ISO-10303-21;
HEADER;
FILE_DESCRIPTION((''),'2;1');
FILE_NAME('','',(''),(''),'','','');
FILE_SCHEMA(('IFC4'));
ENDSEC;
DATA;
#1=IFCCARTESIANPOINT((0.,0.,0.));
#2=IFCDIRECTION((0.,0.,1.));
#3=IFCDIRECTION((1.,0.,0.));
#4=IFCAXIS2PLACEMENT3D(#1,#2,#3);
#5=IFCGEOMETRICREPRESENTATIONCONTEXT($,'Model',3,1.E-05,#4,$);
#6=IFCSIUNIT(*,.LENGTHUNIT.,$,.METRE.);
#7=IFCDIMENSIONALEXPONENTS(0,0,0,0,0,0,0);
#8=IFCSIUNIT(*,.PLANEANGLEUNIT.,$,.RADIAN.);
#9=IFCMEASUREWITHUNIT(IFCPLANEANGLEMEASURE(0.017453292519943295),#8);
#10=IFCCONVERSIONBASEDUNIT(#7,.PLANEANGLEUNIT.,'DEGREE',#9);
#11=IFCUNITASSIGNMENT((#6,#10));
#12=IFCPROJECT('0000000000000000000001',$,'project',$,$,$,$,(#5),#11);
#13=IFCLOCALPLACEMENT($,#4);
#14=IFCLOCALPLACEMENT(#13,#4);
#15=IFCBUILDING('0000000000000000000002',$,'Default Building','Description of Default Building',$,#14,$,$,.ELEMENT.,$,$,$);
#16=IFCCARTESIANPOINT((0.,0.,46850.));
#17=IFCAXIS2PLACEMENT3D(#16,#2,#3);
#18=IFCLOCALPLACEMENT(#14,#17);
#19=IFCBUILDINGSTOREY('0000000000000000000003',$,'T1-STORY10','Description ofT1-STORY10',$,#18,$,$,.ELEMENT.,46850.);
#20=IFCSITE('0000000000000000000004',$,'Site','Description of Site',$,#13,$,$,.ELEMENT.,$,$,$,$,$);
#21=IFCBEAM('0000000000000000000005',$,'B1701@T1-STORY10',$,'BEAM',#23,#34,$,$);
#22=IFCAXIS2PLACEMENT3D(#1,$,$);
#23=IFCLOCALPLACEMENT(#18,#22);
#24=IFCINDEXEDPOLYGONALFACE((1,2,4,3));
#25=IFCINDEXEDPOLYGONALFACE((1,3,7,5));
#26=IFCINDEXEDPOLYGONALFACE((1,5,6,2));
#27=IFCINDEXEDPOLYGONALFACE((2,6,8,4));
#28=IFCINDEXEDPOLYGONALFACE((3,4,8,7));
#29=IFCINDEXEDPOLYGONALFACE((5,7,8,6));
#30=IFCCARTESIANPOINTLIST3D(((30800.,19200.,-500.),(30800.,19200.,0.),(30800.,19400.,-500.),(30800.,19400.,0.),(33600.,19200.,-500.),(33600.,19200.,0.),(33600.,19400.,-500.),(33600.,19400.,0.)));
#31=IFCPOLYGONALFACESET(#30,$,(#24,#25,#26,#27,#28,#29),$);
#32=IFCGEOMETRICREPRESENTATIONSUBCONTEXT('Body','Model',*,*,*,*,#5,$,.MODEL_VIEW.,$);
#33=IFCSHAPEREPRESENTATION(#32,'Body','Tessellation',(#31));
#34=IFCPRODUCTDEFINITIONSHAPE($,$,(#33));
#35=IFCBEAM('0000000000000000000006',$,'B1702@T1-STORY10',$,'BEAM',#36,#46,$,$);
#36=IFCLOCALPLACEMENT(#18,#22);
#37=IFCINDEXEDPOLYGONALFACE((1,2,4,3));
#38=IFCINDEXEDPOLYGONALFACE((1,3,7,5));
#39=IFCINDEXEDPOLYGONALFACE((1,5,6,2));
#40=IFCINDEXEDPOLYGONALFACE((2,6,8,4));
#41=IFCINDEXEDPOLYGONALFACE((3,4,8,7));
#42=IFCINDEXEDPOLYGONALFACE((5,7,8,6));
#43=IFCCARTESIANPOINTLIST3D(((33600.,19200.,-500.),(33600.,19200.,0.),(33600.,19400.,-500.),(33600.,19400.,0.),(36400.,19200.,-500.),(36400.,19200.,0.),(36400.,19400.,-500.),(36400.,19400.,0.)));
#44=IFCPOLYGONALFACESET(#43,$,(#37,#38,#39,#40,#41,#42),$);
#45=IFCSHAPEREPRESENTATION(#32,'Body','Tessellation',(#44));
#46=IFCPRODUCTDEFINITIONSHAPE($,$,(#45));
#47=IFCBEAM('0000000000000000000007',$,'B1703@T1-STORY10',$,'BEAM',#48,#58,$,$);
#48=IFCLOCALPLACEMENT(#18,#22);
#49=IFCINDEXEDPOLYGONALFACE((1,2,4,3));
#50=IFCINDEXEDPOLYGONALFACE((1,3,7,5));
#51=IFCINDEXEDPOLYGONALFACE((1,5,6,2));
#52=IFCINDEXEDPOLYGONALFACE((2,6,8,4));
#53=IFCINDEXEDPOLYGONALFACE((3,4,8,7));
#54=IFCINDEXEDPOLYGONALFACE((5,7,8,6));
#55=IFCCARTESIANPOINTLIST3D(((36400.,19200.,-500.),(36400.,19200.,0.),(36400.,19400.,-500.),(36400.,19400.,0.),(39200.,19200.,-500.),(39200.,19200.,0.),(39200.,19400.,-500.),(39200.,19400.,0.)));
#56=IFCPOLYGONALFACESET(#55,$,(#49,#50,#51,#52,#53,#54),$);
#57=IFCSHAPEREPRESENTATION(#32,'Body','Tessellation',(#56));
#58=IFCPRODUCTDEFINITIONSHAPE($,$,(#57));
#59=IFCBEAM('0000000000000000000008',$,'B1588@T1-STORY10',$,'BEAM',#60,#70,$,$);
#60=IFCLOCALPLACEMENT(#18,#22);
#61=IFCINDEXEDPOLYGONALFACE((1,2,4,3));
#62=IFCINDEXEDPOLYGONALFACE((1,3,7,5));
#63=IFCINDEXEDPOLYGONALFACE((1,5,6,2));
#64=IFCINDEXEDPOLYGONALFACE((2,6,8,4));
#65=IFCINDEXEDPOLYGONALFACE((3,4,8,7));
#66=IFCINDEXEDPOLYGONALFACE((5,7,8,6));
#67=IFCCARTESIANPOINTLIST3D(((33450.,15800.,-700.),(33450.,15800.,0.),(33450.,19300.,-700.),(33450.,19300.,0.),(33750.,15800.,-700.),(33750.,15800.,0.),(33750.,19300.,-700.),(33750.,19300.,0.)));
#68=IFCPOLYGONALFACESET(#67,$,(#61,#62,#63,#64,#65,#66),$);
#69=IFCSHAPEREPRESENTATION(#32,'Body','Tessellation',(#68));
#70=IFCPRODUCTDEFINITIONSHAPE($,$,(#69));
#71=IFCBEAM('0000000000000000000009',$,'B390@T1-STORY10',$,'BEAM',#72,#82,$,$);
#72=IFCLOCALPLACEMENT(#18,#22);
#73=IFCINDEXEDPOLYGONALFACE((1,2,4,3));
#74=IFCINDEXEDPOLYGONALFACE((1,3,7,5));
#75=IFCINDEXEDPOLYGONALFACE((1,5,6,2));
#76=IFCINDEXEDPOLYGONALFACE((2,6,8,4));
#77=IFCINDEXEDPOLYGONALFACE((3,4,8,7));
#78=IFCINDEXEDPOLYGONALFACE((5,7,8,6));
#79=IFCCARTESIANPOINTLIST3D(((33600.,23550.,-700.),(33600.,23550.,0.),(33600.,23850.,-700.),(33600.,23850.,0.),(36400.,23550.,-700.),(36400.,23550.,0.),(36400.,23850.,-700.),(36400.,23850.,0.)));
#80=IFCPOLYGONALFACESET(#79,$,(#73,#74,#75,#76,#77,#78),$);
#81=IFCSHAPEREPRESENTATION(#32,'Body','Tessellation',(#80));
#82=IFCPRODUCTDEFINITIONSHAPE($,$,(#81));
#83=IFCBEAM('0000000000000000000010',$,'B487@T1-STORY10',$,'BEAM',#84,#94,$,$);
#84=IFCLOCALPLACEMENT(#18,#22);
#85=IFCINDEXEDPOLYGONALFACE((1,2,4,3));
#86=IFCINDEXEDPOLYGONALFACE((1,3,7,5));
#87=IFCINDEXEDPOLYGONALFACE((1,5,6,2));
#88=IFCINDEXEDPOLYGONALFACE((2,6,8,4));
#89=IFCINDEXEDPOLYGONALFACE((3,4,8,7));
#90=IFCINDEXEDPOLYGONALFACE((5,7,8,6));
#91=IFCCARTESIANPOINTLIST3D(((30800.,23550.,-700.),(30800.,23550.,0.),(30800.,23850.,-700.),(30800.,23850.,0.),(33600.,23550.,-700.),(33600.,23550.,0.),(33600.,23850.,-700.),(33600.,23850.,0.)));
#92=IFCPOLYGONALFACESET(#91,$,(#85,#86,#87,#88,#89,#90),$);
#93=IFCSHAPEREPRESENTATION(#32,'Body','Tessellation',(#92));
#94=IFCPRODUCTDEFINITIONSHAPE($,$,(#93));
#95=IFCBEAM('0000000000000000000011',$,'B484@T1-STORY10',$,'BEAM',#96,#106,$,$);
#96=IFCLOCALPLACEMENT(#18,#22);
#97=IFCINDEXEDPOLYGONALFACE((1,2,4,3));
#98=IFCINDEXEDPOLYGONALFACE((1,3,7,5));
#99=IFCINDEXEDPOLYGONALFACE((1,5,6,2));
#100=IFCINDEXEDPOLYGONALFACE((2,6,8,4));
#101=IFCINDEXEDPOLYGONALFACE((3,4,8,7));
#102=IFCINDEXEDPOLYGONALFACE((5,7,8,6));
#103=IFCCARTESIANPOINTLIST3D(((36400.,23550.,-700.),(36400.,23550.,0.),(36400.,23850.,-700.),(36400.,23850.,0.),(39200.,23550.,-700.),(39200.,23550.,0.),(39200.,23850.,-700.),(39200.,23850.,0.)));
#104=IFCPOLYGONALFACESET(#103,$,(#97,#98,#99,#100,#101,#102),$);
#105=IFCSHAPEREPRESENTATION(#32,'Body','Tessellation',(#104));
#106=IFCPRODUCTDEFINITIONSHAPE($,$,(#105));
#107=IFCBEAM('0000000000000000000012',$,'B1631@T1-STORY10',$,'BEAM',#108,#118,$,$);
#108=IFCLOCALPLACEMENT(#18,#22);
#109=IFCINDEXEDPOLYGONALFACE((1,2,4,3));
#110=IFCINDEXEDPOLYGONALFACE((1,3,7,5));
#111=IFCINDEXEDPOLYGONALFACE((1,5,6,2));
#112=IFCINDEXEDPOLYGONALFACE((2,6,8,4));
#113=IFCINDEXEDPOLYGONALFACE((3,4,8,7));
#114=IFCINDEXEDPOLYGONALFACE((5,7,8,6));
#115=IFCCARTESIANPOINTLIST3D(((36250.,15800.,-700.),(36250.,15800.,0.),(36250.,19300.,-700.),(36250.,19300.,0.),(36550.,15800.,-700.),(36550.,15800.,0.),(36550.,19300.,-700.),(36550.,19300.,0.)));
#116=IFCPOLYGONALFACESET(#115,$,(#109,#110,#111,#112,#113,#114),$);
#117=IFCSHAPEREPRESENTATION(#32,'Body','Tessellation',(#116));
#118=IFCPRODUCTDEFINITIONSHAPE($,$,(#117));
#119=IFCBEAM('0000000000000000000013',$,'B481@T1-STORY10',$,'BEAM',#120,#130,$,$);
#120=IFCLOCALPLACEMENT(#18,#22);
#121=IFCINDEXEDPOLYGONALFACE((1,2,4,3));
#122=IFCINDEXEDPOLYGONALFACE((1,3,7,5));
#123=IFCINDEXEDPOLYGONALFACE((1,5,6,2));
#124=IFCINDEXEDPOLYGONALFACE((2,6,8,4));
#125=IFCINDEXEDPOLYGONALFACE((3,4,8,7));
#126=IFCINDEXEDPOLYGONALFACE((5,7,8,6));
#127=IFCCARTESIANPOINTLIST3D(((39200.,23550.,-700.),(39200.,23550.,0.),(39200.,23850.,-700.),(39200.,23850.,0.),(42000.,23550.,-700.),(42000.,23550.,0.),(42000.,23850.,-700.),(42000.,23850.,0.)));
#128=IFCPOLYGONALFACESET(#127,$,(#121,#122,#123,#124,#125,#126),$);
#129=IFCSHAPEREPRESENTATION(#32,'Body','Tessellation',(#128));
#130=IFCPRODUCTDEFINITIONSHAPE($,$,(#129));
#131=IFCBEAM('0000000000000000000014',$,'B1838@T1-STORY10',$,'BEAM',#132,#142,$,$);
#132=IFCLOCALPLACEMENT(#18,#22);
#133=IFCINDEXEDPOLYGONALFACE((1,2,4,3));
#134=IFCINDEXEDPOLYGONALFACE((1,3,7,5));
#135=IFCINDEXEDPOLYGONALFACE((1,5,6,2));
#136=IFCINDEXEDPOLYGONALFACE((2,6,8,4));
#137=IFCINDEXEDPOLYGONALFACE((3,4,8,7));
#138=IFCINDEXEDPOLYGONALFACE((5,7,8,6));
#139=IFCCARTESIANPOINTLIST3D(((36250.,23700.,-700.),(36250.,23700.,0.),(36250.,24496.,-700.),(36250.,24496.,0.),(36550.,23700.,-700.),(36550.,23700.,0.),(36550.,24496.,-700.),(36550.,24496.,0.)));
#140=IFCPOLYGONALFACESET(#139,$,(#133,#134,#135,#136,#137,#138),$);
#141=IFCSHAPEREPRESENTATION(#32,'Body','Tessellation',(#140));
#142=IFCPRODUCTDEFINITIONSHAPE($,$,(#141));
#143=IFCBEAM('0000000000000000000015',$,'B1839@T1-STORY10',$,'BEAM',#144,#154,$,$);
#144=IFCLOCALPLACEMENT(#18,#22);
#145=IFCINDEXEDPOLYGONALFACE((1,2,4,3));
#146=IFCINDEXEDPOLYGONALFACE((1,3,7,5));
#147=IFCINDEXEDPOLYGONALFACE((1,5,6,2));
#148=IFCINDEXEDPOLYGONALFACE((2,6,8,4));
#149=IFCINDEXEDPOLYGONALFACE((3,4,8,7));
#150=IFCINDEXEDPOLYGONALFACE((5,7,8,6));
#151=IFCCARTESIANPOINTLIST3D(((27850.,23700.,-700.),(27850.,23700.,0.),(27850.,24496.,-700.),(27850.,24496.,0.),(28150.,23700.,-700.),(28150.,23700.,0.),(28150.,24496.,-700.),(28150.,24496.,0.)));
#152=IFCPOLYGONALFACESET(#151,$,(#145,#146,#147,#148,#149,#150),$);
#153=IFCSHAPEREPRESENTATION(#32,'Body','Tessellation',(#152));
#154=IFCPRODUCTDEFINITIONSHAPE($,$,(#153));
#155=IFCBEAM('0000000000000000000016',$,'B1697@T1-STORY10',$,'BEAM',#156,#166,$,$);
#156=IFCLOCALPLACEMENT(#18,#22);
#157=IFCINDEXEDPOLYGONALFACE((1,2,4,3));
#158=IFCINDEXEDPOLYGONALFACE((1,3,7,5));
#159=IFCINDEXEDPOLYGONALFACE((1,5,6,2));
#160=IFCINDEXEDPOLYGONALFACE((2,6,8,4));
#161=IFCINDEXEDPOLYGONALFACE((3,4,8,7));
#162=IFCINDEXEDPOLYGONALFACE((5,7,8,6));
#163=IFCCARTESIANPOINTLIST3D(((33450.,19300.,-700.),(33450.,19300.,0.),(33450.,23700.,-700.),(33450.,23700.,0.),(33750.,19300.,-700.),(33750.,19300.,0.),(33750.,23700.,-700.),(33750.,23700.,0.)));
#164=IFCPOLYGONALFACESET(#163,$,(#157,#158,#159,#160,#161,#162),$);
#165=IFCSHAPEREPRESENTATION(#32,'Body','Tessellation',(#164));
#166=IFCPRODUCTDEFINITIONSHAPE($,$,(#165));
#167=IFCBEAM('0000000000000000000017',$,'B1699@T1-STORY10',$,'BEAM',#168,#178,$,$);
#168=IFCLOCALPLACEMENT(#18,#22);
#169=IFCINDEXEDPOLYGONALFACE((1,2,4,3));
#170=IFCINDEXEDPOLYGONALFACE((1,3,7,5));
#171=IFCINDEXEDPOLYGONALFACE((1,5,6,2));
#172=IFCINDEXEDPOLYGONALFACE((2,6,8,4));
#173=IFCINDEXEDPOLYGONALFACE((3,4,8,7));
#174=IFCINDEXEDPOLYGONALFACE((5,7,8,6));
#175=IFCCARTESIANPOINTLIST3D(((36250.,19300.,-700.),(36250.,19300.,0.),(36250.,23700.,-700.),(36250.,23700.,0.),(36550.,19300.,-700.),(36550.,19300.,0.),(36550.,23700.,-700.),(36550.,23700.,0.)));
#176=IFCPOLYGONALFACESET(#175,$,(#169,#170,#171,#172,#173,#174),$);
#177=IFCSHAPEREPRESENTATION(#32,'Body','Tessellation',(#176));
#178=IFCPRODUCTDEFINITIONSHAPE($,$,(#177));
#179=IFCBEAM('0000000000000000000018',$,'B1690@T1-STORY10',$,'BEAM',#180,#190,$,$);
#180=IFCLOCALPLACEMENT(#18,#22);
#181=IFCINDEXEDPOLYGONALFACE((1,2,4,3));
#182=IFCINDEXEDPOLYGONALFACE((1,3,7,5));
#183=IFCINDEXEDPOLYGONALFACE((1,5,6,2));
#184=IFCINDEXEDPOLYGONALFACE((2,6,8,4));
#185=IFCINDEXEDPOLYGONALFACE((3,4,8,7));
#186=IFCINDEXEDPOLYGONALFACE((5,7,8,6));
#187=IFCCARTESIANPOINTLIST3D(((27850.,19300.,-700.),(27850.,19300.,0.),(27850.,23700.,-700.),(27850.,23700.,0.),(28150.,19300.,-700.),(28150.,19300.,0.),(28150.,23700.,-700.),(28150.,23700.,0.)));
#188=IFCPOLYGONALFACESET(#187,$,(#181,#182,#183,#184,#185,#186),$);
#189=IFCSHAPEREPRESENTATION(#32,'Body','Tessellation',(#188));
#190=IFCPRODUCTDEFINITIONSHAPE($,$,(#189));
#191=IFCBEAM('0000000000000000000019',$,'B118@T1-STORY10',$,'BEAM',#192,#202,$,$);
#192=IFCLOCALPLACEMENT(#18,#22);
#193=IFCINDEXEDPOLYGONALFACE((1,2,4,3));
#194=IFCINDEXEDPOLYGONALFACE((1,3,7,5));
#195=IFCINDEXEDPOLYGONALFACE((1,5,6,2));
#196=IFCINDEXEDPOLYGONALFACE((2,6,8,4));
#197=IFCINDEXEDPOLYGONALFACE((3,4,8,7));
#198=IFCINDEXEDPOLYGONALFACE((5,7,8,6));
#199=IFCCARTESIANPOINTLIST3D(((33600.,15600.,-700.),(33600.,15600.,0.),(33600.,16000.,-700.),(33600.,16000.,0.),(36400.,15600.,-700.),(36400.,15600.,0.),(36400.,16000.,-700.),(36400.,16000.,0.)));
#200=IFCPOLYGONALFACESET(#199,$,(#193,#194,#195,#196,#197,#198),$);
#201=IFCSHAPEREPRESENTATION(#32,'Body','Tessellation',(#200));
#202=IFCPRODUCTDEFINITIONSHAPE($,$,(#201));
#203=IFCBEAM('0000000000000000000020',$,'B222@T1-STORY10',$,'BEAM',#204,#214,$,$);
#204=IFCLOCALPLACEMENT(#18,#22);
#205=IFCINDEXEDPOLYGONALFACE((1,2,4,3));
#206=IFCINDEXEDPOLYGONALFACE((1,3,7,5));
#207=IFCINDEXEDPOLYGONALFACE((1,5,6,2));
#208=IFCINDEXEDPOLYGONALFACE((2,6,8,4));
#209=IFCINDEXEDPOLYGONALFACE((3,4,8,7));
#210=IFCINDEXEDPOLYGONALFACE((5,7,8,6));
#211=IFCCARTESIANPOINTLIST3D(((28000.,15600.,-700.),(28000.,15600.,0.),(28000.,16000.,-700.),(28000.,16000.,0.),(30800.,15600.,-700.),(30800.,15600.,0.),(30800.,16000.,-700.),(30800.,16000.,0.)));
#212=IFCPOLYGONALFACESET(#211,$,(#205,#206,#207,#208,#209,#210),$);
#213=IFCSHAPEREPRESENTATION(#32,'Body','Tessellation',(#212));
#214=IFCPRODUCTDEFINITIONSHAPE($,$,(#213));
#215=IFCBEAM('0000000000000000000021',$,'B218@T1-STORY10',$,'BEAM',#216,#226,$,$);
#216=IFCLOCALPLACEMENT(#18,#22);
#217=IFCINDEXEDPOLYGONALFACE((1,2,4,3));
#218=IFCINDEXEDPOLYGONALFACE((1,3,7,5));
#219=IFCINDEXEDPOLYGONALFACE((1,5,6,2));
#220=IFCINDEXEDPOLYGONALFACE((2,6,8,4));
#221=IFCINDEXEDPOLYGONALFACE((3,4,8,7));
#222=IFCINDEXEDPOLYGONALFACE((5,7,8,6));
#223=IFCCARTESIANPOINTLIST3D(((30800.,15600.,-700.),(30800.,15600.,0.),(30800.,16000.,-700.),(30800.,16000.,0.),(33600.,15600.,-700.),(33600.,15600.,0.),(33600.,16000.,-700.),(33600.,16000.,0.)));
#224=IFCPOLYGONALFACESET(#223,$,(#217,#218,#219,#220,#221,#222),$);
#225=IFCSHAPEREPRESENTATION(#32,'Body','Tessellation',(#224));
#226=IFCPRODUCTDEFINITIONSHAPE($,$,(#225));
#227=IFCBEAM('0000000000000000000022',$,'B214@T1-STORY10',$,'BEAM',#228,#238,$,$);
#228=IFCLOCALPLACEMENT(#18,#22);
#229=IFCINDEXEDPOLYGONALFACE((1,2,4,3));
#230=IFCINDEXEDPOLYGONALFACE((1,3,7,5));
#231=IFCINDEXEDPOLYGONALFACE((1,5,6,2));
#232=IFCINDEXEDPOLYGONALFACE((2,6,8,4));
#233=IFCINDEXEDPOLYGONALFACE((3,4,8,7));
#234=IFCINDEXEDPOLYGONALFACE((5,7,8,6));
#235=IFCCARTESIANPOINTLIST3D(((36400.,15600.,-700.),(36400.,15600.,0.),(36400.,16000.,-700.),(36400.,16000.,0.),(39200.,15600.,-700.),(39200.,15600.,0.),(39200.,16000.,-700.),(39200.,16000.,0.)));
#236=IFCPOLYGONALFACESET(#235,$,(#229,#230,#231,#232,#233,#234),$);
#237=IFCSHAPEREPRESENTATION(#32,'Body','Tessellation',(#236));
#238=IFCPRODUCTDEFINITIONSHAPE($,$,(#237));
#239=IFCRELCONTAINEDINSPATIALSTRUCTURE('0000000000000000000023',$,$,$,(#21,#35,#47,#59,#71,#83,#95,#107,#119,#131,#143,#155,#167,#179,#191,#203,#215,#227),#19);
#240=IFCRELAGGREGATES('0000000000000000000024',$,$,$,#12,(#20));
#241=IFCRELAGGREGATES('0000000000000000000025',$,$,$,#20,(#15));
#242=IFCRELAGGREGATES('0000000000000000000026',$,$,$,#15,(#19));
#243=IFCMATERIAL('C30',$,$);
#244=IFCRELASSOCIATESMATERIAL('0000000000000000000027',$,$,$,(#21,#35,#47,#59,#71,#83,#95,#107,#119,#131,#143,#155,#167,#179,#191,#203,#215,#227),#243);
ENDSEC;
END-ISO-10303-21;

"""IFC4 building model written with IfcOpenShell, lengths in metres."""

from ifc_helpers import new_model, entity, si_unit, converted_unit, frame, origin_with_axes, place, context, subcontext, project, spatial, rectangle, extrude, material, element, save


model = new_model("IFC4")

# Units and contexts
model_context = context("Model", 3, precision=1e-05, world=origin_with_axes())
body_context = subcontext(model_context, "Body", "Model", "MODEL_VIEW")
ifc_project = project(units=[si_unit("LENGTHUNIT", "METRE"), converted_unit("PLANEANGLEUNIT", "DEGREE", entity("IfcPlaneAngleMeasure", 0.017453292519943295), si_unit("PLANEANGLEUNIT", "RADIAN"), dimensions=[0, 0, 0, 0, 0, 0, 0])], contexts=[model_context])

# Site, building, storey
site_placement = place(None, origin_with_axes())
site = spatial("IfcSite", under=ifc_project, at=site_placement, Name="Site", Description="Description of Site", CompositionType="ELEMENT")
building_placement = place(site_placement, origin_with_axes())
building = spatial("IfcBuilding", under=site, at=building_placement, Name="Default Building", Description="Description of Default Building", CompositionType="ELEMENT")
storey_placement = place(building_placement, frame((0.0, 0.0, 46850.0), z_axis=(0.0, 0.0, 1.0), x_axis=(1.0, 0.0, 0.0)))
storey = spatial("IfcBuildingStorey", under=building, at=storey_placement, Name="T1-STORY10", Description="Description ofT1-STORY10", CompositionType="ELEMENT", Elevation=46850.0)

# Beams
ifc_material_1 = material(Name="C30")
for number, where, z_axis, x_axis, name in (
    (1, (30800.0, 19300.0, -250.0), (1.0, 0.0, 0.0), (0.0, 1.0, 0.0), "B1701@T1-STORY10"),
    (2, (33600.0, 19300.0, -250.0), (1.0, 0.0, 0.0), (0.0, 1.0, 0.0), "B1702@T1-STORY10"),
    (3, (36400.0, 19300.0, -250.0), (1.0, 0.0, 0.0), (0.0, 1.0, 0.0), "B1703@T1-STORY10"),
):
    element("IfcBeam", number, at=place(storey_placement, frame(where, z_axis=z_axis, x_axis=x_axis)), inside=storey, material=ifc_material_1, Name=name, ObjectType="BEAM", context=body_context, shape_type="SweptSolid", body=[
        extrude(rectangle(XDim=200.0, YDim=500.0), origin_with_axes(), (0.0, 0.0, 1.0), 2800.0),
    ])
beam_1_placement = place(storey_placement, frame((33600.0, 15800.0, -350.0), z_axis=(0.0, 1.0, 0.0), x_axis=(-1.0, 0.0, 0.0)))
element("IfcBeam", 4, at=beam_1_placement, inside=storey, material=ifc_material_1, Name="B1588@T1-STORY10", ObjectType="BEAM", context=body_context, shape_type="SweptSolid", body=[
    extrude(rectangle(XDim=300.0, YDim=700.0), origin_with_axes(), (0.0, 0.0, 1.0), 3500.0),
])
for number, where, z_axis, x_axis, name in (
    (5, (33600.0, 23700.0, -350.0), (1.0, 0.0, 0.0), (0.0, 1.0, 0.0), "B390@T1-STORY10"),
    (6, (30800.0, 23700.0, -350.0), (1.0, 0.0, 0.0), (0.0, 1.0, 0.0), "B487@T1-STORY10"),
    (7, (36400.0, 23700.0, -350.0), (1.0, 0.0, 0.0), (0.0, 1.0, 0.0), "B484@T1-STORY10"),
):
    element("IfcBeam", number, at=place(storey_placement, frame(where, z_axis=z_axis, x_axis=x_axis)), inside=storey, material=ifc_material_1, Name=name, ObjectType="BEAM", context=body_context, shape_type="SweptSolid", body=[
        extrude(rectangle(XDim=300.0, YDim=700.0), origin_with_axes(), (0.0, 0.0, 1.0), 2800.0),
    ])
beam_2_placement = place(storey_placement, frame((36400.0, 15800.0, -350.0), z_axis=(0.0, 1.0, 0.0), x_axis=(-1.0, 0.0, 0.0)))
element("IfcBeam", 8, at=beam_2_placement, inside=storey, material=ifc_material_1, Name="B1631@T1-STORY10", ObjectType="BEAM", context=body_context, shape_type="SweptSolid", body=[
    extrude(rectangle(XDim=300.0, YDim=700.0), origin_with_axes(), (0.0, 0.0, 1.0), 3500.0),
])
beam_3_placement = place(storey_placement, frame((39200.0, 23700.0, -350.0), z_axis=(1.0, 0.0, 0.0), x_axis=(0.0, 1.0, 0.0)))
element("IfcBeam", 9, at=beam_3_placement, inside=storey, material=ifc_material_1, Name="B481@T1-STORY10", ObjectType="BEAM", context=body_context, shape_type="SweptSolid", body=[
    extrude(rectangle(XDim=300.0, YDim=700.0), origin_with_axes(), (0.0, 0.0, 1.0), 2800.0),
])
for number, where, z_axis, x_axis, name in (
    (10, (36400.0, 23700.0, -350.0), (0.0, 1.0, 0.0), (-1.0, 0.0, 0.0), "B1838@T1-STORY10"),
    (11, (28000.0, 23700.0, -350.0), (0.0, 1.0, 0.0), (-1.0, 0.0, 0.0), "B1839@T1-STORY10"),
):
    element("IfcBeam", number, at=place(storey_placement, frame(where, z_axis=z_axis, x_axis=x_axis)), inside=storey, material=ifc_material_1, Name=name, ObjectType="BEAM", context=body_context, shape_type="SweptSolid", body=[
        extrude(rectangle(XDim=300.0, YDim=700.0), origin_with_axes(), (0.0, 0.0, 1.0), 796.0),
    ])
for number, where, z_axis, x_axis, name in (
    (12, (33600.0, 19300.0, -350.0), (0.0, 1.0, 0.0), (-1.0, 0.0, 0.0), "B1697@T1-STORY10"),
    (13, (36400.0, 19300.0, -350.0), (0.0, 1.0, 0.0), (-1.0, 0.0, 0.0), "B1699@T1-STORY10"),
    (14, (28000.0, 19300.0, -350.0), (0.0, 1.0, 0.0), (-1.0, 0.0, 0.0), "B1690@T1-STORY10"),
):
    element("IfcBeam", number, at=place(storey_placement, frame(where, z_axis=z_axis, x_axis=x_axis)), inside=storey, material=ifc_material_1, Name=name, ObjectType="BEAM", context=body_context, shape_type="SweptSolid", body=[
        extrude(rectangle(XDim=300.0, YDim=700.0), origin_with_axes(), (0.0, 0.0, 1.0), 4400.0),
    ])
for number, where, z_axis, x_axis, name in (
    (15, (33600.0, 15800.0, -350.0), (1.0, 0.0, 0.0), (0.0, 1.0, 0.0), "B118@T1-STORY10"),
    (16, (28000.0, 15800.0, -350.0), (1.0, 0.0, 0.0), (0.0, 1.0, 0.0), "B222@T1-STORY10"),
    (17, (30800.0, 15800.0, -350.0), (1.0, 0.0, 0.0), (0.0, 1.0, 0.0), "B218@T1-STORY10"),
    (18, (36400.0, 15800.0, -350.0), (1.0, 0.0, 0.0), (0.0, 1.0, 0.0), "B214@T1-STORY10"),
):
    element("IfcBeam", number, at=place(storey_placement, frame(where, z_axis=z_axis, x_axis=x_axis)), inside=storey, material=ifc_material_1, Name=name, ObjectType="BEAM", context=body_context, shape_type="SweptSolid", body=[
        extrude(rectangle(XDim=400.0, YDim=700.0), origin_with_axes(), (0.0, 0.0, 1.0), 2800.0),
    ])

save(model, "model.ifc")
